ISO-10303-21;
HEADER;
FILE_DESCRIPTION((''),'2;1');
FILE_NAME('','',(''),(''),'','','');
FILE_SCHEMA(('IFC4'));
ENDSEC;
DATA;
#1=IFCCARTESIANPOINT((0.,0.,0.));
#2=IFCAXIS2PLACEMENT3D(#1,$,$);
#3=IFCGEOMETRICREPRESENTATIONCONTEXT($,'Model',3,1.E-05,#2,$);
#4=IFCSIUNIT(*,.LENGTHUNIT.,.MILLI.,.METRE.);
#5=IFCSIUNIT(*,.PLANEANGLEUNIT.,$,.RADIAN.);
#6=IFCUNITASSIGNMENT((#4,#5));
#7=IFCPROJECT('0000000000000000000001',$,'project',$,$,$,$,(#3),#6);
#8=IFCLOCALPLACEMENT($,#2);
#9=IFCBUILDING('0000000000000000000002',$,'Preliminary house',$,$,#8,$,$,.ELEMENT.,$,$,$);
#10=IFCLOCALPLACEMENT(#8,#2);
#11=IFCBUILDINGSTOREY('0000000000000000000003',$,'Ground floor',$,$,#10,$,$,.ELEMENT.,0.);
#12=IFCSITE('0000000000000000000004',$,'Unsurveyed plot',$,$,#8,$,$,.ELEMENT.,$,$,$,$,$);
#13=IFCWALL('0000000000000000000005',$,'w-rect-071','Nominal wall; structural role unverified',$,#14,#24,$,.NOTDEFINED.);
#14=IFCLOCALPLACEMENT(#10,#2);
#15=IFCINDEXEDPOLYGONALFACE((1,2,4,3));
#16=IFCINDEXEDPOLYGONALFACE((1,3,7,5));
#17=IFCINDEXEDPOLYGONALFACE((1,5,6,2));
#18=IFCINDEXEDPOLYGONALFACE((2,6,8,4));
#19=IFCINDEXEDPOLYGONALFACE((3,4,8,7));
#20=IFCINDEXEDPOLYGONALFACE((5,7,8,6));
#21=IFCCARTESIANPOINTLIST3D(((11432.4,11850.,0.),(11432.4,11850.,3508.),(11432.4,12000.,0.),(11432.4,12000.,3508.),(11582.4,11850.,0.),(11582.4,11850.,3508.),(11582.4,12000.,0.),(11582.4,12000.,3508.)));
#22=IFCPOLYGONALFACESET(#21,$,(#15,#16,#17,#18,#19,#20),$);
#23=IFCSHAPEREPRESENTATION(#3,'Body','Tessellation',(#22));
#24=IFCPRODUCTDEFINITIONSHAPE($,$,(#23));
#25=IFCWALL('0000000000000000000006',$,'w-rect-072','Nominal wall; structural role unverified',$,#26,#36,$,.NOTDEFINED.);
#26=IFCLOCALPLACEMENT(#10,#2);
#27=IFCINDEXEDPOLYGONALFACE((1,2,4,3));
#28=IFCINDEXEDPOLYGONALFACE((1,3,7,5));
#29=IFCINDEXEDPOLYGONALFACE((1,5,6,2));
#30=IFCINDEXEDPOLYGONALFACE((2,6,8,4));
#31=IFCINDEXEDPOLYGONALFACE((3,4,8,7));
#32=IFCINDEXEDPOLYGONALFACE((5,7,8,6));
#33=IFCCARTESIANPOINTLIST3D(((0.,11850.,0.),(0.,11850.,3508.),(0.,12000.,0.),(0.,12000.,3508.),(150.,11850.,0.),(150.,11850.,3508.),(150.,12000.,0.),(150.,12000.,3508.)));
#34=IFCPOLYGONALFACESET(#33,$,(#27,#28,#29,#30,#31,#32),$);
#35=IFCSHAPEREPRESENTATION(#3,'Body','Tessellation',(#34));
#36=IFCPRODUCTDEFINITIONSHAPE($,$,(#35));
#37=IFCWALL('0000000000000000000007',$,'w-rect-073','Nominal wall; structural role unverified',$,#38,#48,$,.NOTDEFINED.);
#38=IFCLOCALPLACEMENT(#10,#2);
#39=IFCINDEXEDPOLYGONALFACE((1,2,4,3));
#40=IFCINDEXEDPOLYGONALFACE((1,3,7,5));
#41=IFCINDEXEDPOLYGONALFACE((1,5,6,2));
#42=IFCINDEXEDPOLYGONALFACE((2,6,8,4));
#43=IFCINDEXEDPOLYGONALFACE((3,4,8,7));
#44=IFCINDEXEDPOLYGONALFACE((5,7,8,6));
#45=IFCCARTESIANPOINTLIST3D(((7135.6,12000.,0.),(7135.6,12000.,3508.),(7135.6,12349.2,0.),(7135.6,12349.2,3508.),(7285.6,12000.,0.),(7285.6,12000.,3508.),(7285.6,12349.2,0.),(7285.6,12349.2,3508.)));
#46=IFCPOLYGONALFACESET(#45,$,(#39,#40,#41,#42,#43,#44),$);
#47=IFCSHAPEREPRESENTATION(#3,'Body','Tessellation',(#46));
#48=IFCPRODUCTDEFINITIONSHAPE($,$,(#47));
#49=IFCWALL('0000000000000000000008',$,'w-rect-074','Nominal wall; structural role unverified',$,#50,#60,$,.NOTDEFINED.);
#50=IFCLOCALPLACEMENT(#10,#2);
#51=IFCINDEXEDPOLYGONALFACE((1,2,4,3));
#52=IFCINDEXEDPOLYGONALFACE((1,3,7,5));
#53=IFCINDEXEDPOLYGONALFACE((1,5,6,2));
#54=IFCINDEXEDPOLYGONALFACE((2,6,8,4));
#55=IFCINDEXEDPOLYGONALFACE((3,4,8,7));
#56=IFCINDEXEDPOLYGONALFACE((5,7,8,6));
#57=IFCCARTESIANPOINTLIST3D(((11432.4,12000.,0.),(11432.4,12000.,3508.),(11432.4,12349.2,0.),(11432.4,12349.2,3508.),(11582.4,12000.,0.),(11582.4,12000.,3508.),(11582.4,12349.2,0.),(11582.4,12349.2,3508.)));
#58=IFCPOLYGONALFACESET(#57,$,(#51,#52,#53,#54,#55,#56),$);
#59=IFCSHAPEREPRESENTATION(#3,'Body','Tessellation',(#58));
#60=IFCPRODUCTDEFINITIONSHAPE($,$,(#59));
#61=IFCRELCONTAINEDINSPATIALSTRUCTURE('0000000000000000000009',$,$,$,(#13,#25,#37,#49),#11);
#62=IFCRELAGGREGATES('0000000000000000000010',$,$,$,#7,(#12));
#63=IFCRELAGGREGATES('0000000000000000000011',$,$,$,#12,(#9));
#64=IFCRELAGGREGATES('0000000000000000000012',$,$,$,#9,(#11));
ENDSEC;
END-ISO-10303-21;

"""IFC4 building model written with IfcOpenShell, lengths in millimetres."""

from ifc_helpers import new_model, si_unit, origin, place, context, project, spatial, polyline, outline, extrude, element, save


model = new_model("IFC4")

# Units and contexts
model_context = context("Model", 3, precision=1e-05, world=origin())
ifc_project = project(units=[si_unit("LENGTHUNIT", "METRE", prefix="MILLI"), si_unit("PLANEANGLEUNIT", "RADIAN")], contexts=[model_context])

# Site, building, storey
placement_1 = place(None, origin())
site = spatial("IfcSite", under=ifc_project, at=placement_1, Name="Unsurveyed plot", CompositionType="ELEMENT")
building = spatial("IfcBuilding", under=site, at=placement_1, Name="Preliminary house", CompositionType="ELEMENT")
placement_2 = place(placement_1, origin())
storey = spatial("IfcBuildingStorey", under=building, at=placement_2, Name="Ground floor", CompositionType="ELEMENT", Elevation=0.0)

# Walls
element("IfcWall", 1, at=placement_2, inside=storey, Name="w-rect-071", Description="Nominal wall; structural role unverified", PredefinedType="NOTDEFINED", context=model_context, shape_type="SweptSolid", body=[
    extrude(outline(polyline([(11432.4, 11850.0), (11582.4, 11850.0), (11582.4, 12000.0), (11432.4, 12000.0), (11432.4, 11850.0)])), origin(), (0.0, 0.0, 1.0), 3508.0),
])
element("IfcWall", 2, at=placement_2, inside=storey, Name="w-rect-072", Description="Nominal wall; structural role unverified", PredefinedType="NOTDEFINED", context=model_context, shape_type="SweptSolid", body=[
    extrude(outline(polyline([(0.0, 11850.0), (150.0, 11850.0), (150.0, 12000.0), (0.0, 12000.0), (0.0, 11850.0)])), origin(), (0.0, 0.0, 1.0), 3508.0),
])
element("IfcWall", 3, at=placement_2, inside=storey, Name="w-rect-073", Description="Nominal wall; structural role unverified", PredefinedType="NOTDEFINED", context=model_context, shape_type="SweptSolid", body=[
    extrude(outline(polyline([(7135.6, 12000.0), (7285.6, 12000.0), (7285.6, 12349.2), (7135.6, 12349.2), (7135.6, 12000.0)])), origin(), (0.0, 0.0, 1.0), 3508.0),
])
element("IfcWall", 4, at=placement_2, inside=storey, Name="w-rect-074", Description="Nominal wall; structural role unverified", PredefinedType="NOTDEFINED", context=model_context, shape_type="SweptSolid", body=[
    extrude(outline(polyline([(11432.4, 12000.0), (11582.4, 12000.0), (11582.4, 12349.2), (11432.4, 12349.2), (11432.4, 12000.0)])), origin(), (0.0, 0.0, 1.0), 3508.0),
])

save(model, "model.ifc")
